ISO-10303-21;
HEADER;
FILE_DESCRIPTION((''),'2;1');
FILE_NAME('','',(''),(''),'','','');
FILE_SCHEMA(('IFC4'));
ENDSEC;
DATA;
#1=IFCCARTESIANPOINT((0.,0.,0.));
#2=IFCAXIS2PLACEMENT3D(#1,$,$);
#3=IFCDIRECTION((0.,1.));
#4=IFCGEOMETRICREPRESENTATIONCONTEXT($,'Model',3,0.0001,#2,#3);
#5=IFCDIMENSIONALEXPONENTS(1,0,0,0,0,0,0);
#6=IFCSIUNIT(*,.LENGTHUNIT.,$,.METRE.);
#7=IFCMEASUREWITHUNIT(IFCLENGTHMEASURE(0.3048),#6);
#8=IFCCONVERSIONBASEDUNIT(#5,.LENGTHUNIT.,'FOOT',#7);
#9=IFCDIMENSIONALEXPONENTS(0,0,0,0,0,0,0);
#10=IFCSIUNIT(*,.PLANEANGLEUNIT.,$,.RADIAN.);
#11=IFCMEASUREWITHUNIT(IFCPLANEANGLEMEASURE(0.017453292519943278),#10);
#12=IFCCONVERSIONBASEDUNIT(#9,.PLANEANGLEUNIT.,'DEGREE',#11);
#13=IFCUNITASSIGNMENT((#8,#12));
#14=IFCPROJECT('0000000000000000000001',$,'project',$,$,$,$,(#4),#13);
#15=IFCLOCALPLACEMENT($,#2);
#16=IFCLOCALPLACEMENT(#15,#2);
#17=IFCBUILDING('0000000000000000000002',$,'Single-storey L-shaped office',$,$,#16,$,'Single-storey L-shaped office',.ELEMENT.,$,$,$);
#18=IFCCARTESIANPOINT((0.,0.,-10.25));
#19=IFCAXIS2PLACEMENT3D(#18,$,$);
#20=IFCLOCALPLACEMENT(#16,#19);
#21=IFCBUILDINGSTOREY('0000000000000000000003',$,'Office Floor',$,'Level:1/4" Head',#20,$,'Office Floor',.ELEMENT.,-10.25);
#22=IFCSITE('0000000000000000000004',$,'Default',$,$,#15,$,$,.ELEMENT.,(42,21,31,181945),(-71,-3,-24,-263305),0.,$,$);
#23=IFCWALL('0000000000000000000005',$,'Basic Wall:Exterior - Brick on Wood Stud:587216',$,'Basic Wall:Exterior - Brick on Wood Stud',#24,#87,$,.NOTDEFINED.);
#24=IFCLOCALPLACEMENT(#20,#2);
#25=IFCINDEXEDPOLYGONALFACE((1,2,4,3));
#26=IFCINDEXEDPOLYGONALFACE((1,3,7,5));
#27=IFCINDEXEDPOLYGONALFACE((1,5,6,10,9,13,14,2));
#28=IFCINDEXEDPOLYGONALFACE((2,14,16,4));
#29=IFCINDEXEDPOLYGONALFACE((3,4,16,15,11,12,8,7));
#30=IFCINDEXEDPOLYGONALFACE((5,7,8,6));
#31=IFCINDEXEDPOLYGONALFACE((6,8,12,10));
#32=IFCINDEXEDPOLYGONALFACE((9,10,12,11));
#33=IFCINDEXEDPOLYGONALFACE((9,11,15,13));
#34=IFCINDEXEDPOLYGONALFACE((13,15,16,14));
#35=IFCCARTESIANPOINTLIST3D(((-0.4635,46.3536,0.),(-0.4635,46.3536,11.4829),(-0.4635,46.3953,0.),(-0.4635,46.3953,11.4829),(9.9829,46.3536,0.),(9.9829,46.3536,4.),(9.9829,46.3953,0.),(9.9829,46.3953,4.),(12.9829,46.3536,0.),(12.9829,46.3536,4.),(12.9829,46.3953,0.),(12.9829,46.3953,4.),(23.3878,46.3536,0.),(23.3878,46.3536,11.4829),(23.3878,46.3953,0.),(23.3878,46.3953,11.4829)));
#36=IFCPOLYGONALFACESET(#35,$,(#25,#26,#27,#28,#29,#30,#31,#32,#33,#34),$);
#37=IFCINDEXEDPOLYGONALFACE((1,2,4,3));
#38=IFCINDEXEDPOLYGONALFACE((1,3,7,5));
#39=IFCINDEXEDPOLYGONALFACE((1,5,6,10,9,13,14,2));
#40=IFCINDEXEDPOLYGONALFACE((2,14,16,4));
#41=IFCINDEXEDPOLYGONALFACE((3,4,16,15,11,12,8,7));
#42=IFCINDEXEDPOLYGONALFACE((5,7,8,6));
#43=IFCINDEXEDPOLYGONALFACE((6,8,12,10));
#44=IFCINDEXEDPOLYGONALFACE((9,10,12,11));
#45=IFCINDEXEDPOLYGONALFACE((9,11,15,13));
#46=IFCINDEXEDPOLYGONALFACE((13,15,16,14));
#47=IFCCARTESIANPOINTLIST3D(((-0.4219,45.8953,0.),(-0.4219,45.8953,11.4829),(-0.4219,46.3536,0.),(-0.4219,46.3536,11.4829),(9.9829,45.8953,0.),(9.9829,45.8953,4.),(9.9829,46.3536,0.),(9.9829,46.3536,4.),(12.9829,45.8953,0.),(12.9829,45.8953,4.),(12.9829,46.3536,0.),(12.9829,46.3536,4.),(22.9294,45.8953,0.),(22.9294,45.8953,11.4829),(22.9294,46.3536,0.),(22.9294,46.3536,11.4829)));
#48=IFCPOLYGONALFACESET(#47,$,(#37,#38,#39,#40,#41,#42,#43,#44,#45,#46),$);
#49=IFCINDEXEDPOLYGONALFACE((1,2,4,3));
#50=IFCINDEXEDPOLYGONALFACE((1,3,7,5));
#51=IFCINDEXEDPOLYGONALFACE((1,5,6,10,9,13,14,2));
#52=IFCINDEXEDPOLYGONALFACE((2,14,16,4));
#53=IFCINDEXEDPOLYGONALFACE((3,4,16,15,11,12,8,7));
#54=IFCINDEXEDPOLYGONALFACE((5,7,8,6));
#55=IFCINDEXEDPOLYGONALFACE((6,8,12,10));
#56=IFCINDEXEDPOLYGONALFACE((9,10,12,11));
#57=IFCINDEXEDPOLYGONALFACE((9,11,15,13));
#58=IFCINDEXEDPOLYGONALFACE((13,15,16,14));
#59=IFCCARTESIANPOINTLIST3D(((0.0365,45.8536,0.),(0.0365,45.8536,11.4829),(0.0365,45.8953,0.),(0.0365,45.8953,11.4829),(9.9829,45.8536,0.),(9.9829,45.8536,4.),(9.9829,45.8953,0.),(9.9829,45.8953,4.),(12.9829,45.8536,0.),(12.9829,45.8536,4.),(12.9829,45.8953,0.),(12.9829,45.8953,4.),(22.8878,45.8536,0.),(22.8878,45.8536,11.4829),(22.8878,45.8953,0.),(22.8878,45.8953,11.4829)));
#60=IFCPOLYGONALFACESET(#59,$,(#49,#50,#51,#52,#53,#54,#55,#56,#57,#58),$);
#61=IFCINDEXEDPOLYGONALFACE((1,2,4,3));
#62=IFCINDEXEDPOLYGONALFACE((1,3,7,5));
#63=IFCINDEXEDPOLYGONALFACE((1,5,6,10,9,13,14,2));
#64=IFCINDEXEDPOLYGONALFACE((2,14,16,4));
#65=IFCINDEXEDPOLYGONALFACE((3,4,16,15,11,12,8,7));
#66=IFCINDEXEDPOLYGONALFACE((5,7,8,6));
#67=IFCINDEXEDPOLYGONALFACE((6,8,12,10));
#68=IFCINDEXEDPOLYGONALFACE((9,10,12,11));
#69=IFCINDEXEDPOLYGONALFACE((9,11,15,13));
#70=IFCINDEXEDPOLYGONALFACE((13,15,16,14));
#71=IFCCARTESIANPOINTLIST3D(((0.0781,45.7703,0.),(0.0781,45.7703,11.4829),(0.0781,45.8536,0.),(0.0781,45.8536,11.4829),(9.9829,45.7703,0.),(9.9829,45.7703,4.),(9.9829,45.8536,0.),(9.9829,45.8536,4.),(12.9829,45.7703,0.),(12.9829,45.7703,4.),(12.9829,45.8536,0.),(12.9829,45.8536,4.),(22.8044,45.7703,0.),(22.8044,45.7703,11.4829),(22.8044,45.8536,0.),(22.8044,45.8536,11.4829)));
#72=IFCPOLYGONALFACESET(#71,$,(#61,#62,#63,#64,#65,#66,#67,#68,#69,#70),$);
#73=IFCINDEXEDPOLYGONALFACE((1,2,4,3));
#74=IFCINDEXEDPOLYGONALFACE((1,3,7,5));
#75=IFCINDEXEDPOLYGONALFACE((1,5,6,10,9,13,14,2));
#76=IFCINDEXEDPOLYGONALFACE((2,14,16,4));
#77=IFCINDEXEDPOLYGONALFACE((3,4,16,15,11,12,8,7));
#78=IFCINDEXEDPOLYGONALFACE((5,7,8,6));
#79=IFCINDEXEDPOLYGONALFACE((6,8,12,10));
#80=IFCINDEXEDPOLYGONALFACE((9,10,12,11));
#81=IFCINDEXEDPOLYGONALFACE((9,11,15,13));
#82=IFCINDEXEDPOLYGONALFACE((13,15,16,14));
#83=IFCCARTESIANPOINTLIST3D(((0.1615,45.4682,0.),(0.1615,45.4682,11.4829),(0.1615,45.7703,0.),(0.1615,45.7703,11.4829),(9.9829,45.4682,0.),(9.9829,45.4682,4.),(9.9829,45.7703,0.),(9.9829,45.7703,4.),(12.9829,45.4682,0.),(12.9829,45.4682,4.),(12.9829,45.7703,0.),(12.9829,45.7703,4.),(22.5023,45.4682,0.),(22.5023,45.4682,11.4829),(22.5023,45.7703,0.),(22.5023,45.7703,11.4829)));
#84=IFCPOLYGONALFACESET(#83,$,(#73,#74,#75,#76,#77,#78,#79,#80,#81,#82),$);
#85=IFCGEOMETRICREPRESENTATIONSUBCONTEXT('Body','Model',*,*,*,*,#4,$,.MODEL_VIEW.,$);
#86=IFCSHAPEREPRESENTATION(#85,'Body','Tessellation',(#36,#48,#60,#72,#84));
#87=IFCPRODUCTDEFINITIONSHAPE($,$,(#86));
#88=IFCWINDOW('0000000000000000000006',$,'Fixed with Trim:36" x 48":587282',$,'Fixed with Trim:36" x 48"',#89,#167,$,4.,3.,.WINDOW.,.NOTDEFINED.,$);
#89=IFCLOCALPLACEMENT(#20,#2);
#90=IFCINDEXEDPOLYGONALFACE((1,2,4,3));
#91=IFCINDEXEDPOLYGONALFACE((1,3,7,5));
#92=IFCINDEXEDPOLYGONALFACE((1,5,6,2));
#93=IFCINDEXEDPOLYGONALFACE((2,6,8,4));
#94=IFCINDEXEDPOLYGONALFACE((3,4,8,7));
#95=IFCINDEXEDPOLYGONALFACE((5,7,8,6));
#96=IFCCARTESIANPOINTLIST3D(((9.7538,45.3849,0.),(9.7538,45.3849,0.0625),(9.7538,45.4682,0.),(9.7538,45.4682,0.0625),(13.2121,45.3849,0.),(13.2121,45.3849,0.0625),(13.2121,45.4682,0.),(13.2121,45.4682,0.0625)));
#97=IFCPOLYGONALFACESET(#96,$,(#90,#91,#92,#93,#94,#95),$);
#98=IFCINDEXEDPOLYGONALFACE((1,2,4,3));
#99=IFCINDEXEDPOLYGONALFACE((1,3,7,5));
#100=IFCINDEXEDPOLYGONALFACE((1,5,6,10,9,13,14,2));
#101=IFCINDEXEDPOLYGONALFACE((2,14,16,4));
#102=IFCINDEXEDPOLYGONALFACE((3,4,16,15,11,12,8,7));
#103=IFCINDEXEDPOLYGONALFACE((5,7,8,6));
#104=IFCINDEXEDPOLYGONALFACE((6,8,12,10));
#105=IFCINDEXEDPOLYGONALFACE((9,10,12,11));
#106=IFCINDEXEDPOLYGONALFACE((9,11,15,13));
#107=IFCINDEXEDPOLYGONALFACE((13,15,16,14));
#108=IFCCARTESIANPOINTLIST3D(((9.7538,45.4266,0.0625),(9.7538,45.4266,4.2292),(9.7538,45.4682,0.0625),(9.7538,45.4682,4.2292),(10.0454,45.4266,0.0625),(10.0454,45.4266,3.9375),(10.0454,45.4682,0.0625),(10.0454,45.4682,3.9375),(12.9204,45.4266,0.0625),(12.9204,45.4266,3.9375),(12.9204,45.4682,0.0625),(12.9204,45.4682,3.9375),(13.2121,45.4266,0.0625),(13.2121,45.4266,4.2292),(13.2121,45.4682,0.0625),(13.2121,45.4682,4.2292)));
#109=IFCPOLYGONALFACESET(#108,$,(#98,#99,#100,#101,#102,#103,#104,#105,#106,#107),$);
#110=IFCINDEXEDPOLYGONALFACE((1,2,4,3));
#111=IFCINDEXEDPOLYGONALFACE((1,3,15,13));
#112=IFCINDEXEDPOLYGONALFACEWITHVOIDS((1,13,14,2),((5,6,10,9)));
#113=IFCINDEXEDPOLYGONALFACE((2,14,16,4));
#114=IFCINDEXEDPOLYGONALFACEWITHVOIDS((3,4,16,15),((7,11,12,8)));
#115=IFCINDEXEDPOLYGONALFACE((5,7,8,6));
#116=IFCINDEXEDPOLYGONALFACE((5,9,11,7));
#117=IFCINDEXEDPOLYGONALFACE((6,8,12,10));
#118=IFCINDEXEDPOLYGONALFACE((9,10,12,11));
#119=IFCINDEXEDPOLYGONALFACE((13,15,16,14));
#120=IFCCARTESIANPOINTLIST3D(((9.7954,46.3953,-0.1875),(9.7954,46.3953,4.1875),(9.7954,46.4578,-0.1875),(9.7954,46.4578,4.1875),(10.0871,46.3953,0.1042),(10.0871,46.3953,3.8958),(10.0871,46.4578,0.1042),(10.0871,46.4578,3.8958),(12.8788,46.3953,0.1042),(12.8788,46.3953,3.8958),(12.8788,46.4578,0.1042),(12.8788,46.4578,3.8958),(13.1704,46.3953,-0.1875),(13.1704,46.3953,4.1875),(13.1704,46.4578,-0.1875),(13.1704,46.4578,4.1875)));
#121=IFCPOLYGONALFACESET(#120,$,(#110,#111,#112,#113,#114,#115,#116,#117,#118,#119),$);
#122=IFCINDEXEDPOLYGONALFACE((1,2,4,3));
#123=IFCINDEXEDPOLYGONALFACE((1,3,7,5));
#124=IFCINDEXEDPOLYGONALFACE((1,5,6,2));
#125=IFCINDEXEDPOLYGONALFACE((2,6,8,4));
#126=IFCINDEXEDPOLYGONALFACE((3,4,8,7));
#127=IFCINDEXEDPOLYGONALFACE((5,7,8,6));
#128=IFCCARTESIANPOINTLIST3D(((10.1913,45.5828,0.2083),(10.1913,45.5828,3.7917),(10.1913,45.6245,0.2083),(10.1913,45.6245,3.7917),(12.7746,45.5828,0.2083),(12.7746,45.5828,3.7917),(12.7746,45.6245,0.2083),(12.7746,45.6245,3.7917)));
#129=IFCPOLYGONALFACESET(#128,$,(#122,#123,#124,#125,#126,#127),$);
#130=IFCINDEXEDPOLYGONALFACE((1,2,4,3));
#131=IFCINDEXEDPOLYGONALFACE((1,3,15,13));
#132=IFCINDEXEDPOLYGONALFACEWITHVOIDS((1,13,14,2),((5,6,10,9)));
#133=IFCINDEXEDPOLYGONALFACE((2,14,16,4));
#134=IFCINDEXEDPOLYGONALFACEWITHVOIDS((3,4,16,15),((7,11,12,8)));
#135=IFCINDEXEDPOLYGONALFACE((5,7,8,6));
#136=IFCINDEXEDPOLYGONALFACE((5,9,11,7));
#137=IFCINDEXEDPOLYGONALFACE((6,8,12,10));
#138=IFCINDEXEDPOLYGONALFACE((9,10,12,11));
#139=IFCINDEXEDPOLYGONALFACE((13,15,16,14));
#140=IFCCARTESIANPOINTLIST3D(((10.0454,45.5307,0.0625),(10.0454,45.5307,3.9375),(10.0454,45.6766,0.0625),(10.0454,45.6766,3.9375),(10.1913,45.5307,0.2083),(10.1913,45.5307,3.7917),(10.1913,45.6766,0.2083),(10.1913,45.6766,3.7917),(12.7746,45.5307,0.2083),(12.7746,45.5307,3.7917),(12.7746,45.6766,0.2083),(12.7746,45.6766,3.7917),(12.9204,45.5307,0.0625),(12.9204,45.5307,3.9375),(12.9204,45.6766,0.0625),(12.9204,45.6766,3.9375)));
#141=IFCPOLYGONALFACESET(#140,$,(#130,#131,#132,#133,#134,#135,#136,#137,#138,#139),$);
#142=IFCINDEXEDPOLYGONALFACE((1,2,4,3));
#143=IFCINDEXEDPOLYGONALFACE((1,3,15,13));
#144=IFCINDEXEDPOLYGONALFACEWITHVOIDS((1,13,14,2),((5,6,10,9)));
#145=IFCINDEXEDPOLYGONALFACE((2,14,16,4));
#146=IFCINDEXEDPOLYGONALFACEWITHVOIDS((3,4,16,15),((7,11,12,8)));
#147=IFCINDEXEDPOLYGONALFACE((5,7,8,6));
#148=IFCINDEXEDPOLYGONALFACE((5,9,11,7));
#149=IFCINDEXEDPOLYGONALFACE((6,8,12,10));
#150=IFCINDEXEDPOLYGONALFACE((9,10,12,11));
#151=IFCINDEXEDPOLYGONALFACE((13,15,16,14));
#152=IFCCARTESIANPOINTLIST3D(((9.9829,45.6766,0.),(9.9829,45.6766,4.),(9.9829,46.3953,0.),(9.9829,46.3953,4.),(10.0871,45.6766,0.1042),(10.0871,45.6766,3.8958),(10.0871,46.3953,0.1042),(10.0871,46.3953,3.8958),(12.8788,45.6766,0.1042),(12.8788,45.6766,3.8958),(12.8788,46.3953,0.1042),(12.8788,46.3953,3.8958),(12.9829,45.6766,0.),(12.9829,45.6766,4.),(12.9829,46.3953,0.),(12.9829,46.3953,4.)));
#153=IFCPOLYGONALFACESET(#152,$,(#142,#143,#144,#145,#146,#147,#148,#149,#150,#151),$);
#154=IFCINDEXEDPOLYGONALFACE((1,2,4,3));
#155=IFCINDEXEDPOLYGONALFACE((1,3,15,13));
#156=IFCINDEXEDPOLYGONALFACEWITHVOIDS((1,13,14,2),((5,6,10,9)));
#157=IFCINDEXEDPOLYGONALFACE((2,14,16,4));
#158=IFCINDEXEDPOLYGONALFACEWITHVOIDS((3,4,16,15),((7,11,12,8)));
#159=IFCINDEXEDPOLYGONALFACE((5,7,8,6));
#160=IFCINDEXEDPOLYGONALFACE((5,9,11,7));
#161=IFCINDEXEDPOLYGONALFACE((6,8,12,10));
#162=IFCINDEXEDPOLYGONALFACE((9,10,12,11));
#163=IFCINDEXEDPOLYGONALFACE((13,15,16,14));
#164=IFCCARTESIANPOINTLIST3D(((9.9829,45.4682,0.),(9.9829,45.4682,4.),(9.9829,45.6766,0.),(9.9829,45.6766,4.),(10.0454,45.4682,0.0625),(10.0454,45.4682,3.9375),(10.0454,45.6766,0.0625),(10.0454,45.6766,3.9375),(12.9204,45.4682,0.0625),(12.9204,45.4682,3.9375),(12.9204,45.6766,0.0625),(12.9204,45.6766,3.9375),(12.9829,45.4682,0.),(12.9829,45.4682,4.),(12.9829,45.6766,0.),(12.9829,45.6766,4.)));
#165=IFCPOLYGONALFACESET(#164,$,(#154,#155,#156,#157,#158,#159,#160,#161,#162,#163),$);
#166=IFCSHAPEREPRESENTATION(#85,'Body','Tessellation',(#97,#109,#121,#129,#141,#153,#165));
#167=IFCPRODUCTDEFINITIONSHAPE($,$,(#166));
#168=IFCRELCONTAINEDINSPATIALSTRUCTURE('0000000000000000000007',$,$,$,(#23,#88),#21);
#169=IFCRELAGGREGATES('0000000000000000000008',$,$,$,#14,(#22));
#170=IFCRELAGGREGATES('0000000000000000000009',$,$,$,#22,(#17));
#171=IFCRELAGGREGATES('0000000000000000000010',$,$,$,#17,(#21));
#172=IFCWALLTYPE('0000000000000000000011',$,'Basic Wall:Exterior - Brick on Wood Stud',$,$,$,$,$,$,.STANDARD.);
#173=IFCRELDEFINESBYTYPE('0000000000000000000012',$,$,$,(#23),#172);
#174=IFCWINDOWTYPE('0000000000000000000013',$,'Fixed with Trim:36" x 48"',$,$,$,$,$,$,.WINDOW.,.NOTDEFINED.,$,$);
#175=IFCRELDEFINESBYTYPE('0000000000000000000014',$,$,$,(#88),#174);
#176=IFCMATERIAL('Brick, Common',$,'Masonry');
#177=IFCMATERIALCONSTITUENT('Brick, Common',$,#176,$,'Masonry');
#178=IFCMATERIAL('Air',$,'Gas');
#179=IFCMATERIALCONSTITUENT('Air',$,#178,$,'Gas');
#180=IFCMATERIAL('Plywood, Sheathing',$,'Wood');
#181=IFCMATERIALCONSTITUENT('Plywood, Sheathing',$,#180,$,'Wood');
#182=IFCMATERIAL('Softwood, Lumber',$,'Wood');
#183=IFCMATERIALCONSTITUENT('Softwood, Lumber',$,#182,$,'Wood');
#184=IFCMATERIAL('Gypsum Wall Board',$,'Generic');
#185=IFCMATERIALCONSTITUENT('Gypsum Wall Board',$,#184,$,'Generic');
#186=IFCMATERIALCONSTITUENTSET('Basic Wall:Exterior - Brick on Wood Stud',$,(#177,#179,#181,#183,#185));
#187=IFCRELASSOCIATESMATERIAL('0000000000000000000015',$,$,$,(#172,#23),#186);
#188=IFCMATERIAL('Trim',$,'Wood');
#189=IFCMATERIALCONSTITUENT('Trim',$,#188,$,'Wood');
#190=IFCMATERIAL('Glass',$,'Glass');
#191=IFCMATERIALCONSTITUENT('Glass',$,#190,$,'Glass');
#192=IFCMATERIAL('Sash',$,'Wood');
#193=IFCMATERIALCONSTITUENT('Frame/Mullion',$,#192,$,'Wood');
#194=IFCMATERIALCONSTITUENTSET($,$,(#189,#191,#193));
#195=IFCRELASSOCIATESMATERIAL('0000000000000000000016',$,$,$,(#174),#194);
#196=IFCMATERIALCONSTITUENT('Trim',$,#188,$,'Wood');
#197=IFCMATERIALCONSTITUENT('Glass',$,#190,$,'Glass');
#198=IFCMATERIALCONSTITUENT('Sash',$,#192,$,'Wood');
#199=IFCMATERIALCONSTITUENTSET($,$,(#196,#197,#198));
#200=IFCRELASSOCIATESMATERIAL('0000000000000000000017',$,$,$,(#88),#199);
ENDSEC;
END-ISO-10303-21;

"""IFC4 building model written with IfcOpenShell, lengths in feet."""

from ifc_helpers import new_model, entity, si_unit, converted_unit, direction, frame, origin, place, context, subcontext, project, spatial, indexed_curve, outline, extrude, source, transform, mapped, material, constituent, constituent_set, type_object, type_shapes, element, fill, save


model = new_model("IFC4")

# Units and contexts
model_context = context("Model", 3, precision=0.0001, world=origin(), true_north=direction((0.0, 1.0)))
body_context = subcontext(model_context, "Body", "Model", "MODEL_VIEW")
ifc_project = project(units=[converted_unit("LENGTHUNIT", "FOOT", entity("IfcLengthMeasure", 0.3048), si_unit("LENGTHUNIT", "METRE"), dimensions=[1, 0, 0, 0, 0, 0, 0]), converted_unit("PLANEANGLEUNIT", "DEGREE", entity("IfcPlaneAngleMeasure", 0.017453292519943278), si_unit("PLANEANGLEUNIT", "RADIAN"), dimensions=[0, 0, 0, 0, 0, 0, 0])], contexts=[model_context])

# Site, building, storey
site_placement = place(None, origin())
site = spatial("IfcSite", under=ifc_project, at=site_placement, Name="Default", CompositionType="ELEMENT", RefLatitude=(42, 21, 31, 181945), RefLongitude=(-71, -3, -24, -263305), RefElevation=0.0)
building_placement = place(site_placement, origin())
building = spatial("IfcBuilding", under=site, at=building_placement, Name="Single-storey L-shaped office", LongName="Single-storey L-shaped office", CompositionType="ELEMENT")
storey_placement = place(building_placement, frame((0.0, 0.0, -10.25)))
storey = spatial("IfcBuildingStorey", under=building, at=storey_placement, Name="Office Floor", ObjectType="Level:1/4\" Head", LongName="Office Floor", CompositionType="ELEMENT", Elevation=-10.25)

# Shared definitions
ifc_material_1 = material(Name="Brick, Common", Category="Masonry")
ifc_constituent_1 = constituent(ifc_material_1, Name="Brick, Common", Category="Masonry")
ifc_material_2 = material(Name="Air", Category="Gas")
ifc_constituent_2 = constituent(ifc_material_2, Name="Air", Category="Gas")
ifc_material_3 = material(Name="Plywood, Sheathing", Category="Wood")
ifc_constituent_3 = constituent(ifc_material_3, Name="Plywood, Sheathing", Category="Wood")
ifc_material_4 = material(Name="Softwood, Lumber", Category="Wood")
ifc_constituent_4 = constituent(ifc_material_4, Name="Softwood, Lumber", Category="Wood")
ifc_material_5 = material(Name="Gypsum Wall Board", Category="Generic")
ifc_constituent_5 = constituent(ifc_material_5, Name="Gypsum Wall Board", Category="Generic")
ifc_constituent_set_1 = constituent_set(constituents=[ifc_constituent_1, ifc_constituent_2, ifc_constituent_3, ifc_constituent_4, ifc_constituent_5], Name="Basic Wall:Exterior - Brick on Wood Stud")
wall_type_1 = type_object("IfcWallType", Name="Basic Wall:Exterior - Brick on Wood Stud", PredefinedType="STANDARD", material=ifc_constituent_set_1)
ifc_material_6 = material(Name="Glass", Category="Glass")
ifc_material_7 = material(Name="Trim", Category="Wood")
ifc_material_8 = material(Name="Sash", Category="Wood")
ifc_constituent_6 = constituent(ifc_material_7, Name="Trim", Category="Wood")
ifc_constituent_7 = constituent(ifc_material_6, Name="Glass", Category="Glass")
ifc_constituent_8 = constituent(ifc_material_8, Name="Frame/Mullion", Category="Wood")
ifc_constituent_set_2 = constituent_set(constituents=[ifc_constituent_6, ifc_constituent_7, ifc_constituent_8])
window_type = type_object("IfcWindowType", Name="Fixed with Trim:36\" x 48\"", PartitioningType="NOTDEFINED", PredefinedType="WINDOW", material=ifc_constituent_set_2)
shared_shape_1 = source(origin(), body_context, "Body", "SweptSolid", [
    extrude(outline(indexed_curve([(-0.0417, -1.7292), (0.0417, -1.7292), (0.0417, 1.7292), (-0.0417, 1.7292), (-0.0417, -1.7292)], self_intersect=False)), frame((1.5, 0.9687, 0.0), z_axis=(0.0, 0.0, 1.0), x_axis=(0.0, -1.0, 0.0)), (0.0, 0.0, 1.0), 0.0625),
    extrude(outline(indexed_curve([(-1.8646, 1.4375), (2.0104, 1.4375), (2.0104, 1.7292), (-2.1562, 1.7292), (-2.1562, -1.7292), (2.0104, -1.7292), (2.0104, -1.4375), (-1.8646, -1.4375), (-1.8646, 1.4375)], self_intersect=False)), frame((1.5, 0.9271, 2.0729), z_axis=(0.0, 1.0, 0.0), x_axis=(0.0, 0.0, -1.0)), (0.0, 0.0, 1.0), 0.0417),
    extrude(outline(indexed_curve([(-2.1875, -1.6875), (2.1875, -1.6875), (2.1875, 1.6875), (-2.1875, 1.6875), (-2.1875, -1.6875)], self_intersect=False), holes=[indexed_curve([(-1.8958, -1.3958), (-1.8958, 1.3958), (1.8958, 1.3958), (1.8958, -1.3958), (-1.8958, -1.3958)], self_intersect=False)]), frame((1.5, -0.0625, 2.0), z_axis=(0.0, 1.0, 0.0), x_axis=(0.0, 0.0, -1.0)), (0.0, 0.0, 1.0), 0.0625),
    extrude(outline(indexed_curve([(-0.0208, -1.2917), (0.0208, -1.2917), (0.0208, 1.2917), (-0.0208, 1.2917), (-0.0208, -1.2917)], self_intersect=False)), frame((1.5, 0.7917, 0.2083), z_axis=(0.0, 0.0, 1.0), x_axis=(0.0, 1.0, 0.0)), (0.0, 0.0, 1.0), 3.5833),
    extrude(outline(indexed_curve([(-1.4375, -1.9375), (1.4375, -1.9375), (1.4375, 1.9375), (-1.4375, 1.9375), (-1.4375, -1.9375)], self_intersect=False), holes=[indexed_curve([(-1.2917, -1.7917), (-1.2917, 1.7917), (1.2917, 1.7917), (1.2917, -1.7917), (-1.2917, -1.7917)], self_intersect=False)]), frame((1.5, 0.7188, 2.0), z_axis=(0.0, 1.0, 0.0), x_axis=(1.0, 0.0, 0.0)), (0.0, 0.0, 1.0), 0.1458),
    extrude(outline(indexed_curve([(-1.5, -2.0), (1.5, -2.0), (1.5, 2.0), (-1.5, 2.0), (-1.5, -2.0)], self_intersect=False), holes=[indexed_curve([(-1.3958, -1.8958), (-1.3958, 1.8958), (1.3958, 1.8958), (1.3958, -1.8958), (-1.3958, -1.8958)], self_intersect=False)]), frame((1.5, 0.0, 2.0), z_axis=(0.0, 1.0, 0.0), x_axis=(1.0, 0.0, 0.0)), (0.0, 0.0, 1.0), 0.7188),
    extrude(outline(indexed_curve([(-2.0, -1.5), (2.0, -1.5), (2.0, 1.5), (-2.0, 1.5), (-2.0, -1.5)], self_intersect=False), holes=[indexed_curve([(-1.9375, -1.4375), (-1.9375, 1.4375), (1.9375, 1.4375), (1.9375, -1.4375), (-1.9375, -1.4375)], self_intersect=False)]), frame((1.5, 0.7188, 2.0), z_axis=(0.0, 1.0, 0.0), x_axis=(0.0, 0.0, -1.0)), (0.0, 0.0, 1.0), 0.2083),
])
type_shapes(window_type, [shared_shape_1])

# Wall, opening, window
wall_1_placement = place(storey_placement, frame((22.5023, 45.9318, 0.0), z_axis=(0.0, 0.0, 1.0), x_axis=(-1.0, 0.0, 0.0)))
wall_1 = element("IfcWall", 1, at=wall_1_placement, inside=storey, type_object=wall_type_1, material=ifc_constituent_set_1, Name="Basic Wall:Exterior - Brick on Wood Stud:587216", ObjectType="Basic Wall:Exterior - Brick on Wood Stud", PredefinedType="NOTDEFINED", context=body_context, shape_type="SweptSolid", body=[
    extrude(outline(indexed_curve([(-3.8707, -1.5104), (-3.8707, -11.9152), (7.6122, -11.9152), (7.6122, 11.9361), (-3.8707, 11.9361), (-3.8707, 1.4896), (0.1293, 1.4896), (0.1293, -1.5104), (-3.8707, -1.5104)], self_intersect=False)), frame((11.0298, -0.4219, 3.8707), z_axis=(0.0, 1.0, 0.0), x_axis=(0.0, 0.0, 1.0)), (0.0, 0.0, -1.0), 0.0417),
    extrude(outline(indexed_curve([(-3.8707, -1.6146), (-3.8707, -11.5611), (7.6122, -11.5611), (7.6122, 11.7902), (-3.8707, 11.7902), (-3.8707, 1.3854), (0.1293, 1.3854), (0.1293, -1.6146), (-3.8707, -1.6146)], self_intersect=False)), frame((11.134, 0.0365, 3.8707), z_axis=(0.0, 1.0, 0.0), x_axis=(0.0, 0.0, 1.0)), (0.0, 0.0, -1.0), 0.4583),
    extrude(outline(indexed_curve([(-3.8707, -1.5104), (-3.8707, -11.4152), (7.6122, -11.4152), (7.6122, 11.4361), (-3.8707, 11.4361), (-3.8707, 1.4896), (0.1293, 1.4896), (0.1293, -1.5104), (-3.8707, -1.5104)], self_intersect=False)), frame((11.0298, 0.0781, 3.8707), z_axis=(0.0, 1.0, 0.0), x_axis=(0.0, 0.0, 1.0)), (0.0, 0.0, -1.0), 0.0417),
    extrude(outline(indexed_curve([(-3.8707, -1.5208), (-3.8707, -11.3423), (7.6122, -11.3423), (7.6122, 11.384), (-3.8707, 11.384), (-3.8707, 1.4792), (0.1293, 1.4792), (0.1293, -1.5208), (-3.8707, -1.5208)], self_intersect=False)), frame((11.0402, 0.1615, 3.8707), z_axis=(0.0, 1.0, 0.0), x_axis=(0.0, 0.0, 1.0)), (0.0, 0.0, -1.0), 0.0833),
    extrude(outline(indexed_curve([(-3.7643, 0.2449), (-3.7643, 4.2449), (-13.2837, 4.2449), (-13.2837, -7.2381), (8.7551, -7.2381), (9.0572, -7.2381), (9.0572, 4.2449), (8.7551, 4.2449), (-0.7643, 4.2449), (-0.7643, 0.2449), (-3.7643, 0.2449)], self_intersect=False)), frame((13.2837, 0.4635, 4.2449), z_axis=(0.0, 1.0, 0.0), x_axis=(1.0, 0.0, 0.0)), (0.0, 0.0, -1.0), 0.3021),
])
opening_1_placement = place(wall_1_placement, frame((9.5194, -0.4635, 0.0)))
opening_1 = element("IfcOpeningElement", 2, at=opening_1_placement, cuts=wall_1, PredefinedType="OPENING", context=body_context, shape_type="SweptSolid", body=[
    extrude(outline(indexed_curve([(4.0, 3.0), (0.0, 3.0), (0.0, 0.0), (4.0, 0.0), (4.0, 3.0)], self_intersect=False)), frame((0.0, 0.0, 0.0), z_axis=(0.0, 1.0, 0.0), x_axis=(0.0, 0.0, 1.0)), (0.0, 0.0, 1.0), 0.9271),
])
ifc_constituent_9 = constituent(ifc_material_7, Name="Trim", Category="Wood")
ifc_constituent_10 = constituent(ifc_material_6, Name="Glass", Category="Glass")
ifc_constituent_11 = constituent(ifc_material_8, Name="Sash", Category="Wood")
ifc_constituent_set_3 = constituent_set(constituents=[ifc_constituent_9, ifc_constituent_10, ifc_constituent_11])
window_1_placement = place(opening_1_placement, origin())
window_1 = element("IfcWindow", 3, at=window_1_placement, inside=storey, type_object=window_type, material=ifc_constituent_set_3, Name="Fixed with Trim:36\" x 48\":587282", ObjectType="Fixed with Trim:36\" x 48\"", OverallHeight=4.0, OverallWidth=3.0, PartitioningType="NOTDEFINED", PredefinedType="WINDOW", context=body_context, shape_type="MappedRepresentation", body=[
    mapped(shared_shape_1, transform((0.0, 0.0, 0.0), scale=1.0)),
])
fill(opening_1, window_1)

save(model, "model.ifc")
